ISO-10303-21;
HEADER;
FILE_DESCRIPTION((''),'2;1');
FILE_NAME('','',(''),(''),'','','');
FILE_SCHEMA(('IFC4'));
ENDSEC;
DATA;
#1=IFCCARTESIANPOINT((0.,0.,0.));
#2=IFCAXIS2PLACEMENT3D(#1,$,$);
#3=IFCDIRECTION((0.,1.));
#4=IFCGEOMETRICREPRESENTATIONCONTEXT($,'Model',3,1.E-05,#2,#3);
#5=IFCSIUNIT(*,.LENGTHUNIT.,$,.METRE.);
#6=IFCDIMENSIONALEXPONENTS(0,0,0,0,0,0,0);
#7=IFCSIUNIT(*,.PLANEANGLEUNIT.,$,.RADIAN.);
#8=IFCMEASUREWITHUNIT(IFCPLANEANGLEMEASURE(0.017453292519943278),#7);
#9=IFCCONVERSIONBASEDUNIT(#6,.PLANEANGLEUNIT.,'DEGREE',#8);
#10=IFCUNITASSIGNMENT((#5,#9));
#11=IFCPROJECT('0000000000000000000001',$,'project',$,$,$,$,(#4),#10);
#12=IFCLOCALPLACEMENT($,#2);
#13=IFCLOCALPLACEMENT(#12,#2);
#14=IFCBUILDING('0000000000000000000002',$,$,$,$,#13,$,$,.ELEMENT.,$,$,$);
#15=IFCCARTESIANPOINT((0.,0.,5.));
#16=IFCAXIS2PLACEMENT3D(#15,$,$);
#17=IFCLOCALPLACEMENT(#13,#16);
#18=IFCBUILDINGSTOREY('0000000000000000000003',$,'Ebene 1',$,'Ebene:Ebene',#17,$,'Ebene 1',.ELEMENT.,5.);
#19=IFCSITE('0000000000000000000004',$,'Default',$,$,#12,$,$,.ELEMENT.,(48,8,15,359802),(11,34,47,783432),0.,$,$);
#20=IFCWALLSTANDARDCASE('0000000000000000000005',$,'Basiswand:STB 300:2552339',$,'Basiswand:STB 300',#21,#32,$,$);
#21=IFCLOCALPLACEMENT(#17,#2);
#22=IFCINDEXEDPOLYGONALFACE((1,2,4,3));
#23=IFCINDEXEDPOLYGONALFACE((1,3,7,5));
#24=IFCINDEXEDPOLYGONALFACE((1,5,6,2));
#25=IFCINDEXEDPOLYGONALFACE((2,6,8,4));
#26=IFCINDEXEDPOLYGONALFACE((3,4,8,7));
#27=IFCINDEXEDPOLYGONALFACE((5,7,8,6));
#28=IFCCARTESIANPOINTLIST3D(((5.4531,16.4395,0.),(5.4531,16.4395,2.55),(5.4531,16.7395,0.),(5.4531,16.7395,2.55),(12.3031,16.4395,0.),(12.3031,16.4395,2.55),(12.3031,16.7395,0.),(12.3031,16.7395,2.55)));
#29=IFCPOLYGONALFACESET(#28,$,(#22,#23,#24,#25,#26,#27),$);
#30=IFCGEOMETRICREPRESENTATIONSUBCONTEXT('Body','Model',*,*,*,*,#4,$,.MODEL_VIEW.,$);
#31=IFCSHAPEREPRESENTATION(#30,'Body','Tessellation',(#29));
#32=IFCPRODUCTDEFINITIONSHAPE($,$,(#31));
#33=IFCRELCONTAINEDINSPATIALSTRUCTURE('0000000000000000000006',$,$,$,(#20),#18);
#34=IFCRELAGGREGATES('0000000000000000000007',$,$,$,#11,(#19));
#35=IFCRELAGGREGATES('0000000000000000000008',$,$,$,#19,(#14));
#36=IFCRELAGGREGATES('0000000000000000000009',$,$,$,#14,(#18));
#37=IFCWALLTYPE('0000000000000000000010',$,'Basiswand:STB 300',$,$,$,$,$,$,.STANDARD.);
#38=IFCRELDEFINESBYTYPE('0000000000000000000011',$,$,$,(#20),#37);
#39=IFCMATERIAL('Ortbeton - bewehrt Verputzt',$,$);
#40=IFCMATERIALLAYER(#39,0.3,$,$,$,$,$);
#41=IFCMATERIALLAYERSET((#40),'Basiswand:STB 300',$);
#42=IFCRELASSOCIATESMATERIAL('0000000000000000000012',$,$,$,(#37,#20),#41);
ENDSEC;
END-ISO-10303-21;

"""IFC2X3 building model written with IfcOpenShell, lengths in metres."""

from ifc_helpers import new_model, entity, si_unit, converted_unit, direction, frame, frame_2d, origin, place, context, subcontext, project, spatial, polyline, rectangle, extrude, clip, bounded_halfspace, material, layer, layer_set, layer_usage, type_object, element, save


model = new_model("IFC2X3")

# Units and contexts
model_context = context("Model", 3, precision=1e-05, world=origin(), true_north=direction((0.0, 1.0)))
body_context = subcontext(model_context, "Body", "Model", "MODEL_VIEW")
ifc_project = project(units=[si_unit("LENGTHUNIT", "METRE"), converted_unit("PLANEANGLEUNIT", "DEGREE", entity("IfcPlaneAngleMeasure", 0.017453292519943278), si_unit("PLANEANGLEUNIT", "RADIAN"), dimensions=[0, 0, 0, 0, 0, 0, 0])], contexts=[model_context])

# Site, building, storey
site_placement = place(None, origin())
site = spatial("IfcSite", under=ifc_project, at=site_placement, Name="Default", CompositionType="ELEMENT", RefLatitude=(48, 8, 15, 359802), RefLongitude=(11, 34, 47, 783432), RefElevation=0.0)
building_placement = place(site_placement, origin())
building = spatial("IfcBuilding", under=site, at=building_placement, CompositionType="ELEMENT")
storey_placement = place(building_placement, frame((0.0, 0.0, 5.0)))
storey = spatial("IfcBuildingStorey", under=building, at=storey_placement, Name="Ebene 1", ObjectType="Ebene:Ebene", LongName="Ebene 1", CompositionType="ELEMENT", Elevation=5.0)

# Shared definitions
ifc_material_1 = material(Name="Ortbeton - bewehrt Verputzt")

# Shared definitions
ifc_layer = layer(ifc_material_1, 0.3)
ifc_layer_set = layer_set([ifc_layer], Name="Basiswand:STB 300")
wall_type = type_object("IfcWallType", Name="Basiswand:STB 300", PredefinedType="STANDARD", material=ifc_layer_set)

# Wall
ifc_layer_usage_1 = layer_usage(ifc_layer_set, "AXIS2", "NEGATIVE", 0.15)
wall_1_placement = place(storey_placement, frame((12.3031, 16.5895, 0.0), z_axis=(0.0, 0.0, 1.0), x_axis=(-1.0, 0.0, 0.0)))
element("IfcWallStandardCase", 1, at=wall_1_placement, inside=storey, type_object=wall_type, material=ifc_layer_usage_1, Name="Basiswand:STB 300:2552339", ObjectType="Basiswand:STB 300", context=body_context, shape_type="Clipping", body=[
    clip(extrude(rectangle(XDim=6.85, YDim=0.3, at=frame_2d((3.425, 0.0), x_axis=(-1.0, 0.0))), origin(), (0.0, 0.0, 1.0), 2.55), bounded_halfspace(frame((0.0, -0.15, 2.55), z_axis=(0.0, 0.0, -1.0), x_axis=(0.0, 1.0, 0.0)), True, frame((0.0, -0.15, 2.55)), polyline([(0.0, 0.0), (6.55, 0.0), (6.85, 0.0), (6.85, 0.3), (0.0, 0.3), (0.0, 0.0)]))),
])

save(model, "model.ifc")
